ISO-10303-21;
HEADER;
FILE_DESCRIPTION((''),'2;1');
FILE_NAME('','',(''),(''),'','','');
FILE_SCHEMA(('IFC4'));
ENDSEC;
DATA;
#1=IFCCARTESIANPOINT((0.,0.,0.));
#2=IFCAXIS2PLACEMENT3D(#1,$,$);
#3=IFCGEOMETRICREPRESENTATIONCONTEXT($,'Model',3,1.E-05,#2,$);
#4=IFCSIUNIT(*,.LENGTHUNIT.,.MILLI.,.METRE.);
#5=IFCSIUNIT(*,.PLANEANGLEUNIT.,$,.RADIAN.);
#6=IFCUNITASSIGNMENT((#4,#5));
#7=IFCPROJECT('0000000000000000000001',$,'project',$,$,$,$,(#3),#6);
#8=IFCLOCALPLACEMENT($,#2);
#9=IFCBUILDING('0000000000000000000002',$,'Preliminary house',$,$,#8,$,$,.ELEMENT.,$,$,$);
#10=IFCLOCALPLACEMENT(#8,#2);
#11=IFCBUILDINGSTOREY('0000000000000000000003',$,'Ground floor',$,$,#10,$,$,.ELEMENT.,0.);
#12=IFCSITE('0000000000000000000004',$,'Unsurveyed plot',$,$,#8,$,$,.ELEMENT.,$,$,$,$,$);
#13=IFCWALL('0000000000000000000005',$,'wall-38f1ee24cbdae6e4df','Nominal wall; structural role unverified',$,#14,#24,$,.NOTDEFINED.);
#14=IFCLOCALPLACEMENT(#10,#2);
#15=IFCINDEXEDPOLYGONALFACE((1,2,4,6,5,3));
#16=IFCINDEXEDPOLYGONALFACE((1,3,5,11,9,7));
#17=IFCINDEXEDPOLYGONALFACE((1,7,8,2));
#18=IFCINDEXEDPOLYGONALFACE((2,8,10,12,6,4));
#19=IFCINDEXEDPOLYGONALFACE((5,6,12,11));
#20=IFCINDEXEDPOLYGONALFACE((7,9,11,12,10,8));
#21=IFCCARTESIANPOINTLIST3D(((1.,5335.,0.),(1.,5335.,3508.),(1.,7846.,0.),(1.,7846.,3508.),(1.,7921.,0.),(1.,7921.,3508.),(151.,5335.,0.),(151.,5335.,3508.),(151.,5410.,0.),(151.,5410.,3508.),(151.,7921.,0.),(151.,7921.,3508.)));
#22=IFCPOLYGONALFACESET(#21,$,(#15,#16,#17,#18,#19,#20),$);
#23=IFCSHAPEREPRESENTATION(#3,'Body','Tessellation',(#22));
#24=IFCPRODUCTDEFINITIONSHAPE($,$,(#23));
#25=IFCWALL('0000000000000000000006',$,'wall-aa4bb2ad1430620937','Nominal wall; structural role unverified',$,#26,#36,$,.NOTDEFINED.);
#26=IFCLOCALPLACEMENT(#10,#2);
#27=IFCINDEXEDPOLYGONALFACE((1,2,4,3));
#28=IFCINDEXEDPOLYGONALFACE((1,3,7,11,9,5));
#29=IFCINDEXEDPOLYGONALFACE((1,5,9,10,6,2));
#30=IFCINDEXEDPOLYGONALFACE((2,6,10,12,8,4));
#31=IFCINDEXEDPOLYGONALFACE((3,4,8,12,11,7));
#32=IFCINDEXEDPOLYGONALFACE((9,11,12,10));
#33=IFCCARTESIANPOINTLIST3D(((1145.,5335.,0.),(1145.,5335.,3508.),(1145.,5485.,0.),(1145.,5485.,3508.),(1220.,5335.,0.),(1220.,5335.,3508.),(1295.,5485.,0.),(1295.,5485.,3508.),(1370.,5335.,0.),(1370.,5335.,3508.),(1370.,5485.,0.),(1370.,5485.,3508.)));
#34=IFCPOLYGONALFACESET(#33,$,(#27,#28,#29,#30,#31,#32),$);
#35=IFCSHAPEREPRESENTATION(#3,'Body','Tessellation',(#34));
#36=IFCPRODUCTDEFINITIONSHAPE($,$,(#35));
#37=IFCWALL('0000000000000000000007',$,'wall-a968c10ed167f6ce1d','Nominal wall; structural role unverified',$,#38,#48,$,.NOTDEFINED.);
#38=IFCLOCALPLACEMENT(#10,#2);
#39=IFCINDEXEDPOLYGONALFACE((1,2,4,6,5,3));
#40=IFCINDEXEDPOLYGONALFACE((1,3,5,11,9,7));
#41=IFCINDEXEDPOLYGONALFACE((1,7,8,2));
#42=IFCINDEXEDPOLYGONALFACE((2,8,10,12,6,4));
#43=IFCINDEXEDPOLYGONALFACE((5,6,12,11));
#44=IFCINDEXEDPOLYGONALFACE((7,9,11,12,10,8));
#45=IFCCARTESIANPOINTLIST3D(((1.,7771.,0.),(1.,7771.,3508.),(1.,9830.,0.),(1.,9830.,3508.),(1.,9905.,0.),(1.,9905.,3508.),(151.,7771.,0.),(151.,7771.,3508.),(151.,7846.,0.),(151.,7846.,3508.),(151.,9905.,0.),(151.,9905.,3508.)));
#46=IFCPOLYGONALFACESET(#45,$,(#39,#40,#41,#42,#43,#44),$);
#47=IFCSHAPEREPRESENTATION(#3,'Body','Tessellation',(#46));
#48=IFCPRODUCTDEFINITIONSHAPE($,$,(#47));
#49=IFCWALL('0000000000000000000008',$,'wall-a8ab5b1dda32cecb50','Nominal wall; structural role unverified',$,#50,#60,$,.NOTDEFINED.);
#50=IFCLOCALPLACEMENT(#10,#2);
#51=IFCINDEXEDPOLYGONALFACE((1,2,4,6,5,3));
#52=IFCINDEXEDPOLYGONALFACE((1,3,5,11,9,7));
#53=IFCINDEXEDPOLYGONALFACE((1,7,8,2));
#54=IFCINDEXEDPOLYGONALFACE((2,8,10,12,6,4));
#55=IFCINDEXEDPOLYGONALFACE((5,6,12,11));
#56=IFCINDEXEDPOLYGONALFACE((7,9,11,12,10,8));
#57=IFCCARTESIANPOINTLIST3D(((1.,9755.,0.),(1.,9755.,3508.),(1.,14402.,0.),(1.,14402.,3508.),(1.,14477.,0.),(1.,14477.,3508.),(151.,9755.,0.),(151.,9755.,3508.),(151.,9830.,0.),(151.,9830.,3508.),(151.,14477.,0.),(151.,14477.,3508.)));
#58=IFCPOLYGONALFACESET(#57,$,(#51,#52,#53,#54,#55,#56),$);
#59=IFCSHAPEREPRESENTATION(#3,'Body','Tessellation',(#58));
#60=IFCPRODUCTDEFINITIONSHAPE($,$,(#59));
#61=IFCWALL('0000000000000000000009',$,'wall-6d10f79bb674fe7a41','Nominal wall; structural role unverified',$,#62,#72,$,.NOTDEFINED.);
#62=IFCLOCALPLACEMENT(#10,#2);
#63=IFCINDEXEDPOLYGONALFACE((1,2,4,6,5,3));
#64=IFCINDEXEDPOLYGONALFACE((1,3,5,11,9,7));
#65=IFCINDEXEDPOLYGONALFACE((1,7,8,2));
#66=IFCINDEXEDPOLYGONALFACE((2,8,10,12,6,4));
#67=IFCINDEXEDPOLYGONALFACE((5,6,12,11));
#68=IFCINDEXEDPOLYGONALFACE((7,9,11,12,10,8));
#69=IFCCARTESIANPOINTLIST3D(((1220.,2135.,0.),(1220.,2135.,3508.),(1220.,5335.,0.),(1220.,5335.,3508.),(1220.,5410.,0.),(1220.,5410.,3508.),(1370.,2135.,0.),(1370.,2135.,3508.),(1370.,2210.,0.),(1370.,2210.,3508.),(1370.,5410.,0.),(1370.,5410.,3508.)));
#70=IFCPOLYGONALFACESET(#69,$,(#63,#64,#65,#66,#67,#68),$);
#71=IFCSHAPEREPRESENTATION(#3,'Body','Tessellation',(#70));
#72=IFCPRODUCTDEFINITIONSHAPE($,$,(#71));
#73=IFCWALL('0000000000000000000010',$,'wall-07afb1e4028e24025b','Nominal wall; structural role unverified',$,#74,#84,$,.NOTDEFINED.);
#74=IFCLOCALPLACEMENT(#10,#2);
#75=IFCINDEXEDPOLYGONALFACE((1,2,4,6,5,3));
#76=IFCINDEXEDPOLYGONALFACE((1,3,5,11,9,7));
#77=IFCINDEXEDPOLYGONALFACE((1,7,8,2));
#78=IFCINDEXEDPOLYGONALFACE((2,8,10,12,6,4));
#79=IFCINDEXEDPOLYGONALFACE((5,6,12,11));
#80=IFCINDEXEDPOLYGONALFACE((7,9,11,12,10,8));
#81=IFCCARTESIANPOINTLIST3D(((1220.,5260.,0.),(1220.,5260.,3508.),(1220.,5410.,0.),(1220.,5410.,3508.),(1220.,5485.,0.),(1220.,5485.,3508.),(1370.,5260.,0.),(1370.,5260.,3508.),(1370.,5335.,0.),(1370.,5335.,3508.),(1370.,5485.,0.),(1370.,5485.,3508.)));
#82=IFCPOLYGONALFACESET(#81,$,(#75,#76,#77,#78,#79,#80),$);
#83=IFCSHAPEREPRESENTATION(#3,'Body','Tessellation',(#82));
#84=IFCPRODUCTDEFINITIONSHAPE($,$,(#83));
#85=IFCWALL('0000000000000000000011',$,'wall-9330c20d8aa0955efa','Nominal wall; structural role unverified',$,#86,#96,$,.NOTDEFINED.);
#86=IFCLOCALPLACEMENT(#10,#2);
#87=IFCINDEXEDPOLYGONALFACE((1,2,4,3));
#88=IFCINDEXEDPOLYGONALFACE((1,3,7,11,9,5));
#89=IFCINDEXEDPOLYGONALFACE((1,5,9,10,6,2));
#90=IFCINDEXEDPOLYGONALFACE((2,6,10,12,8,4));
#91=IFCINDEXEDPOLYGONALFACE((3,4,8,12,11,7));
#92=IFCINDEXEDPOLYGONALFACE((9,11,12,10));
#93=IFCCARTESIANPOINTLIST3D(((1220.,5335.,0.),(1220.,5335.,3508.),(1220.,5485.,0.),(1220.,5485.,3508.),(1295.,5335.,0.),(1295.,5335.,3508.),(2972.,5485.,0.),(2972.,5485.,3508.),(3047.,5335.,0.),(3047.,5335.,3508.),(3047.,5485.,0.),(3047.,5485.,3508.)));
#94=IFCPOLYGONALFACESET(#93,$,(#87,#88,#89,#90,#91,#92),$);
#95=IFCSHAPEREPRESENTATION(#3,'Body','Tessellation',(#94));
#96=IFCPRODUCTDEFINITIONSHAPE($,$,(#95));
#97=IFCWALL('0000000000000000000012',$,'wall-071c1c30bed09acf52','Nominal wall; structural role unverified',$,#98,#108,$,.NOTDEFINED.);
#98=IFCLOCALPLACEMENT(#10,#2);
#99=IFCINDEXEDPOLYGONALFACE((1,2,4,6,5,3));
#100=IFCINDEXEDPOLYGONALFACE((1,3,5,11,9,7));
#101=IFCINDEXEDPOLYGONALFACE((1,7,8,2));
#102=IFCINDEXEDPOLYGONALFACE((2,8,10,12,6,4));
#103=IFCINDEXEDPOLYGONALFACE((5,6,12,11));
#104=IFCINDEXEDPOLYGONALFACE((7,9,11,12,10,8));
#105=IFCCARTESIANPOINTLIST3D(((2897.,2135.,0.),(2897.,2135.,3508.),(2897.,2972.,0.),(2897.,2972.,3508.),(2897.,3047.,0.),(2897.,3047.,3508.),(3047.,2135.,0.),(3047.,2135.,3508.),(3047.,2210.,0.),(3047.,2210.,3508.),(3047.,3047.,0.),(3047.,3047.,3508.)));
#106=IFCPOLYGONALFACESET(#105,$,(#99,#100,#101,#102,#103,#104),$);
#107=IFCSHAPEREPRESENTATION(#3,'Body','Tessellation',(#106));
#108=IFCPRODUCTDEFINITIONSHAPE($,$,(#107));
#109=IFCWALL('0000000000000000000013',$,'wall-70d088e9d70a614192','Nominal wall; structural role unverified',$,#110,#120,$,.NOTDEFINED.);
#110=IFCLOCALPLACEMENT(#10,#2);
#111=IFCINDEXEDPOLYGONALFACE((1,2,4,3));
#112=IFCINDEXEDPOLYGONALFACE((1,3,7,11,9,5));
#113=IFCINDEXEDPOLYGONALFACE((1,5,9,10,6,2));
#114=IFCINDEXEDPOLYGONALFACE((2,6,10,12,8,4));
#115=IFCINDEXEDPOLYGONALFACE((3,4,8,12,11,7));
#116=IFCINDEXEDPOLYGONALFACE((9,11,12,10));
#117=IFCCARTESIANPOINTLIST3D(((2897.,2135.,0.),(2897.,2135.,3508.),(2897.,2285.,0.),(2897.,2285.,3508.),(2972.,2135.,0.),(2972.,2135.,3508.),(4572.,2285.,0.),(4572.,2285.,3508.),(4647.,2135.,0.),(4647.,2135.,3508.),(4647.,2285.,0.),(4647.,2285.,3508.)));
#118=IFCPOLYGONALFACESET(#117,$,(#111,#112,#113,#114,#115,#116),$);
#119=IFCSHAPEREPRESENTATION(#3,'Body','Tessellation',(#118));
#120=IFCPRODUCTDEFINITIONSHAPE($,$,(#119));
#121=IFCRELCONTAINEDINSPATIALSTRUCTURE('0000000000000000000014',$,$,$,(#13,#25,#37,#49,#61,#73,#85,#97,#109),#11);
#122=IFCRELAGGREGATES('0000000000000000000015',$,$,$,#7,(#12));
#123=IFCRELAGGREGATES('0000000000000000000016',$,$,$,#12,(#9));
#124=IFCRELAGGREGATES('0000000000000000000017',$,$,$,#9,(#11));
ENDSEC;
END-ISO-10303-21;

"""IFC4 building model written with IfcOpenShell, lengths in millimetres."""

from ifc_helpers import new_model, si_unit, origin, place, context, project, spatial, polyline, outline, extrude, element, save


model = new_model("IFC4")

# Units and contexts
model_context = context("Model", 3, precision=1e-05, world=origin())
ifc_project = project(units=[si_unit("LENGTHUNIT", "METRE", prefix="MILLI"), si_unit("PLANEANGLEUNIT", "RADIAN")], contexts=[model_context])

# Site, building, storey
placement_1 = place(None, origin())
site = spatial("IfcSite", under=ifc_project, at=placement_1, Name="Unsurveyed plot", CompositionType="ELEMENT")
building = spatial("IfcBuilding", under=site, at=placement_1, Name="Preliminary house", CompositionType="ELEMENT")
placement_2 = place(placement_1, origin())
storey = spatial("IfcBuildingStorey", under=building, at=placement_2, Name="Ground floor", CompositionType="ELEMENT", Elevation=0.0)

# Wall
element("IfcWall", 1, at=placement_2, inside=storey, Name="wall-38f1ee24cbdae6e4df", Description="Nominal wall; structural role unverified", PredefinedType="NOTDEFINED", context=model_context, shape_type="SweptSolid", body=[
    extrude(outline(polyline([(1.0, 7846.0), (1.0, 7921.0), (151.0, 7921.0), (151.0, 5410.0), (151.0, 5335.0), (1.0, 5335.0), (1.0, 7846.0)])), origin(), (0.0, 0.0, 1.0), 3508.0),
])

# Walls
element("IfcWall", 2, at=placement_2, inside=storey, Name="wall-aa4bb2ad1430620937", Description="Nominal wall; structural role unverified", PredefinedType="NOTDEFINED", context=model_context, shape_type="SweptSolid", body=[
    extrude(outline(polyline([(1295.0, 5485.0), (1370.0, 5485.0), (1370.0, 5335.0), (1220.0, 5335.0), (1145.0, 5335.0), (1145.0, 5485.0), (1295.0, 5485.0)])), origin(), (0.0, 0.0, 1.0), 3508.0),
])
element("IfcWall", 3, at=placement_2, inside=storey, Name="wall-a968c10ed167f6ce1d", Description="Nominal wall; structural role unverified", PredefinedType="NOTDEFINED", context=model_context, shape_type="SweptSolid", body=[
    extrude(outline(polyline([(1.0, 9830.0), (1.0, 9905.0), (151.0, 9905.0), (151.0, 7846.0), (151.0, 7771.0), (1.0, 7771.0), (1.0, 9830.0)])), origin(), (0.0, 0.0, 1.0), 3508.0),
])

# Wall
element("IfcWall", 4, at=placement_2, inside=storey, Name="wall-a8ab5b1dda32cecb50", Description="Nominal wall; structural role unverified", PredefinedType="NOTDEFINED", context=model_context, shape_type="SweptSolid", body=[
    extrude(outline(polyline([(1.0, 14402.0), (1.0, 14477.0), (151.0, 14477.0), (151.0, 9830.0), (151.0, 9755.0), (1.0, 9755.0), (1.0, 14402.0)])), origin(), (0.0, 0.0, 1.0), 3508.0),
])

# Walls
element("IfcWall", 5, at=placement_2, inside=storey, Name="wall-6d10f79bb674fe7a41", Description="Nominal wall; structural role unverified", PredefinedType="NOTDEFINED", context=model_context, shape_type="SweptSolid", body=[
    extrude(outline(polyline([(1220.0, 5335.0), (1220.0, 5410.0), (1370.0, 5410.0), (1370.0, 2210.0), (1370.0, 2135.0), (1220.0, 2135.0), (1220.0, 5335.0)])), origin(), (0.0, 0.0, 1.0), 3508.0),
])
element("IfcWall", 6, at=placement_2, inside=storey, Name="wall-07afb1e4028e24025b", Description="Nominal wall; structural role unverified", PredefinedType="NOTDEFINED", context=model_context, shape_type="SweptSolid", body=[
    extrude(outline(polyline([(1220.0, 5410.0), (1220.0, 5485.0), (1370.0, 5485.0), (1370.0, 5335.0), (1370.0, 5260.0), (1220.0, 5260.0), (1220.0, 5410.0)])), origin(), (0.0, 0.0, 1.0), 3508.0),
])

# Walls
element("IfcWall", 7, at=placement_2, inside=storey, Name="wall-9330c20d8aa0955efa", Description="Nominal wall; structural role unverified", PredefinedType="NOTDEFINED", context=model_context, shape_type="SweptSolid", body=[
    extrude(outline(polyline([(2972.0, 5485.0), (3047.0, 5485.0), (3047.0, 5335.0), (1295.0, 5335.0), (1220.0, 5335.0), (1220.0, 5485.0), (2972.0, 5485.0)])), origin(), (0.0, 0.0, 1.0), 3508.0),
])
element("IfcWall", 8, at=placement_2, inside=storey, Name="wall-071c1c30bed09acf52", Description="Nominal wall; structural role unverified", PredefinedType="NOTDEFINED", context=model_context, shape_type="SweptSolid", body=[
    extrude(outline(polyline([(2897.0, 2972.0), (2897.0, 3047.0), (3047.0, 3047.0), (3047.0, 2210.0), (3047.0, 2135.0), (2897.0, 2135.0), (2897.0, 2972.0)])), origin(), (0.0, 0.0, 1.0), 3508.0),
])
element("IfcWall", 9, at=placement_2, inside=storey, Name="wall-70d088e9d70a614192", Description="Nominal wall; structural role unverified", PredefinedType="NOTDEFINED", context=model_context, shape_type="SweptSolid", body=[
    extrude(outline(polyline([(4572.0, 2285.0), (4647.0, 2285.0), (4647.0, 2135.0), (2972.0, 2135.0), (2897.0, 2135.0), (2897.0, 2285.0), (4572.0, 2285.0)])), origin(), (0.0, 0.0, 1.0), 3508.0),
])

save(model, "model.ifc")
